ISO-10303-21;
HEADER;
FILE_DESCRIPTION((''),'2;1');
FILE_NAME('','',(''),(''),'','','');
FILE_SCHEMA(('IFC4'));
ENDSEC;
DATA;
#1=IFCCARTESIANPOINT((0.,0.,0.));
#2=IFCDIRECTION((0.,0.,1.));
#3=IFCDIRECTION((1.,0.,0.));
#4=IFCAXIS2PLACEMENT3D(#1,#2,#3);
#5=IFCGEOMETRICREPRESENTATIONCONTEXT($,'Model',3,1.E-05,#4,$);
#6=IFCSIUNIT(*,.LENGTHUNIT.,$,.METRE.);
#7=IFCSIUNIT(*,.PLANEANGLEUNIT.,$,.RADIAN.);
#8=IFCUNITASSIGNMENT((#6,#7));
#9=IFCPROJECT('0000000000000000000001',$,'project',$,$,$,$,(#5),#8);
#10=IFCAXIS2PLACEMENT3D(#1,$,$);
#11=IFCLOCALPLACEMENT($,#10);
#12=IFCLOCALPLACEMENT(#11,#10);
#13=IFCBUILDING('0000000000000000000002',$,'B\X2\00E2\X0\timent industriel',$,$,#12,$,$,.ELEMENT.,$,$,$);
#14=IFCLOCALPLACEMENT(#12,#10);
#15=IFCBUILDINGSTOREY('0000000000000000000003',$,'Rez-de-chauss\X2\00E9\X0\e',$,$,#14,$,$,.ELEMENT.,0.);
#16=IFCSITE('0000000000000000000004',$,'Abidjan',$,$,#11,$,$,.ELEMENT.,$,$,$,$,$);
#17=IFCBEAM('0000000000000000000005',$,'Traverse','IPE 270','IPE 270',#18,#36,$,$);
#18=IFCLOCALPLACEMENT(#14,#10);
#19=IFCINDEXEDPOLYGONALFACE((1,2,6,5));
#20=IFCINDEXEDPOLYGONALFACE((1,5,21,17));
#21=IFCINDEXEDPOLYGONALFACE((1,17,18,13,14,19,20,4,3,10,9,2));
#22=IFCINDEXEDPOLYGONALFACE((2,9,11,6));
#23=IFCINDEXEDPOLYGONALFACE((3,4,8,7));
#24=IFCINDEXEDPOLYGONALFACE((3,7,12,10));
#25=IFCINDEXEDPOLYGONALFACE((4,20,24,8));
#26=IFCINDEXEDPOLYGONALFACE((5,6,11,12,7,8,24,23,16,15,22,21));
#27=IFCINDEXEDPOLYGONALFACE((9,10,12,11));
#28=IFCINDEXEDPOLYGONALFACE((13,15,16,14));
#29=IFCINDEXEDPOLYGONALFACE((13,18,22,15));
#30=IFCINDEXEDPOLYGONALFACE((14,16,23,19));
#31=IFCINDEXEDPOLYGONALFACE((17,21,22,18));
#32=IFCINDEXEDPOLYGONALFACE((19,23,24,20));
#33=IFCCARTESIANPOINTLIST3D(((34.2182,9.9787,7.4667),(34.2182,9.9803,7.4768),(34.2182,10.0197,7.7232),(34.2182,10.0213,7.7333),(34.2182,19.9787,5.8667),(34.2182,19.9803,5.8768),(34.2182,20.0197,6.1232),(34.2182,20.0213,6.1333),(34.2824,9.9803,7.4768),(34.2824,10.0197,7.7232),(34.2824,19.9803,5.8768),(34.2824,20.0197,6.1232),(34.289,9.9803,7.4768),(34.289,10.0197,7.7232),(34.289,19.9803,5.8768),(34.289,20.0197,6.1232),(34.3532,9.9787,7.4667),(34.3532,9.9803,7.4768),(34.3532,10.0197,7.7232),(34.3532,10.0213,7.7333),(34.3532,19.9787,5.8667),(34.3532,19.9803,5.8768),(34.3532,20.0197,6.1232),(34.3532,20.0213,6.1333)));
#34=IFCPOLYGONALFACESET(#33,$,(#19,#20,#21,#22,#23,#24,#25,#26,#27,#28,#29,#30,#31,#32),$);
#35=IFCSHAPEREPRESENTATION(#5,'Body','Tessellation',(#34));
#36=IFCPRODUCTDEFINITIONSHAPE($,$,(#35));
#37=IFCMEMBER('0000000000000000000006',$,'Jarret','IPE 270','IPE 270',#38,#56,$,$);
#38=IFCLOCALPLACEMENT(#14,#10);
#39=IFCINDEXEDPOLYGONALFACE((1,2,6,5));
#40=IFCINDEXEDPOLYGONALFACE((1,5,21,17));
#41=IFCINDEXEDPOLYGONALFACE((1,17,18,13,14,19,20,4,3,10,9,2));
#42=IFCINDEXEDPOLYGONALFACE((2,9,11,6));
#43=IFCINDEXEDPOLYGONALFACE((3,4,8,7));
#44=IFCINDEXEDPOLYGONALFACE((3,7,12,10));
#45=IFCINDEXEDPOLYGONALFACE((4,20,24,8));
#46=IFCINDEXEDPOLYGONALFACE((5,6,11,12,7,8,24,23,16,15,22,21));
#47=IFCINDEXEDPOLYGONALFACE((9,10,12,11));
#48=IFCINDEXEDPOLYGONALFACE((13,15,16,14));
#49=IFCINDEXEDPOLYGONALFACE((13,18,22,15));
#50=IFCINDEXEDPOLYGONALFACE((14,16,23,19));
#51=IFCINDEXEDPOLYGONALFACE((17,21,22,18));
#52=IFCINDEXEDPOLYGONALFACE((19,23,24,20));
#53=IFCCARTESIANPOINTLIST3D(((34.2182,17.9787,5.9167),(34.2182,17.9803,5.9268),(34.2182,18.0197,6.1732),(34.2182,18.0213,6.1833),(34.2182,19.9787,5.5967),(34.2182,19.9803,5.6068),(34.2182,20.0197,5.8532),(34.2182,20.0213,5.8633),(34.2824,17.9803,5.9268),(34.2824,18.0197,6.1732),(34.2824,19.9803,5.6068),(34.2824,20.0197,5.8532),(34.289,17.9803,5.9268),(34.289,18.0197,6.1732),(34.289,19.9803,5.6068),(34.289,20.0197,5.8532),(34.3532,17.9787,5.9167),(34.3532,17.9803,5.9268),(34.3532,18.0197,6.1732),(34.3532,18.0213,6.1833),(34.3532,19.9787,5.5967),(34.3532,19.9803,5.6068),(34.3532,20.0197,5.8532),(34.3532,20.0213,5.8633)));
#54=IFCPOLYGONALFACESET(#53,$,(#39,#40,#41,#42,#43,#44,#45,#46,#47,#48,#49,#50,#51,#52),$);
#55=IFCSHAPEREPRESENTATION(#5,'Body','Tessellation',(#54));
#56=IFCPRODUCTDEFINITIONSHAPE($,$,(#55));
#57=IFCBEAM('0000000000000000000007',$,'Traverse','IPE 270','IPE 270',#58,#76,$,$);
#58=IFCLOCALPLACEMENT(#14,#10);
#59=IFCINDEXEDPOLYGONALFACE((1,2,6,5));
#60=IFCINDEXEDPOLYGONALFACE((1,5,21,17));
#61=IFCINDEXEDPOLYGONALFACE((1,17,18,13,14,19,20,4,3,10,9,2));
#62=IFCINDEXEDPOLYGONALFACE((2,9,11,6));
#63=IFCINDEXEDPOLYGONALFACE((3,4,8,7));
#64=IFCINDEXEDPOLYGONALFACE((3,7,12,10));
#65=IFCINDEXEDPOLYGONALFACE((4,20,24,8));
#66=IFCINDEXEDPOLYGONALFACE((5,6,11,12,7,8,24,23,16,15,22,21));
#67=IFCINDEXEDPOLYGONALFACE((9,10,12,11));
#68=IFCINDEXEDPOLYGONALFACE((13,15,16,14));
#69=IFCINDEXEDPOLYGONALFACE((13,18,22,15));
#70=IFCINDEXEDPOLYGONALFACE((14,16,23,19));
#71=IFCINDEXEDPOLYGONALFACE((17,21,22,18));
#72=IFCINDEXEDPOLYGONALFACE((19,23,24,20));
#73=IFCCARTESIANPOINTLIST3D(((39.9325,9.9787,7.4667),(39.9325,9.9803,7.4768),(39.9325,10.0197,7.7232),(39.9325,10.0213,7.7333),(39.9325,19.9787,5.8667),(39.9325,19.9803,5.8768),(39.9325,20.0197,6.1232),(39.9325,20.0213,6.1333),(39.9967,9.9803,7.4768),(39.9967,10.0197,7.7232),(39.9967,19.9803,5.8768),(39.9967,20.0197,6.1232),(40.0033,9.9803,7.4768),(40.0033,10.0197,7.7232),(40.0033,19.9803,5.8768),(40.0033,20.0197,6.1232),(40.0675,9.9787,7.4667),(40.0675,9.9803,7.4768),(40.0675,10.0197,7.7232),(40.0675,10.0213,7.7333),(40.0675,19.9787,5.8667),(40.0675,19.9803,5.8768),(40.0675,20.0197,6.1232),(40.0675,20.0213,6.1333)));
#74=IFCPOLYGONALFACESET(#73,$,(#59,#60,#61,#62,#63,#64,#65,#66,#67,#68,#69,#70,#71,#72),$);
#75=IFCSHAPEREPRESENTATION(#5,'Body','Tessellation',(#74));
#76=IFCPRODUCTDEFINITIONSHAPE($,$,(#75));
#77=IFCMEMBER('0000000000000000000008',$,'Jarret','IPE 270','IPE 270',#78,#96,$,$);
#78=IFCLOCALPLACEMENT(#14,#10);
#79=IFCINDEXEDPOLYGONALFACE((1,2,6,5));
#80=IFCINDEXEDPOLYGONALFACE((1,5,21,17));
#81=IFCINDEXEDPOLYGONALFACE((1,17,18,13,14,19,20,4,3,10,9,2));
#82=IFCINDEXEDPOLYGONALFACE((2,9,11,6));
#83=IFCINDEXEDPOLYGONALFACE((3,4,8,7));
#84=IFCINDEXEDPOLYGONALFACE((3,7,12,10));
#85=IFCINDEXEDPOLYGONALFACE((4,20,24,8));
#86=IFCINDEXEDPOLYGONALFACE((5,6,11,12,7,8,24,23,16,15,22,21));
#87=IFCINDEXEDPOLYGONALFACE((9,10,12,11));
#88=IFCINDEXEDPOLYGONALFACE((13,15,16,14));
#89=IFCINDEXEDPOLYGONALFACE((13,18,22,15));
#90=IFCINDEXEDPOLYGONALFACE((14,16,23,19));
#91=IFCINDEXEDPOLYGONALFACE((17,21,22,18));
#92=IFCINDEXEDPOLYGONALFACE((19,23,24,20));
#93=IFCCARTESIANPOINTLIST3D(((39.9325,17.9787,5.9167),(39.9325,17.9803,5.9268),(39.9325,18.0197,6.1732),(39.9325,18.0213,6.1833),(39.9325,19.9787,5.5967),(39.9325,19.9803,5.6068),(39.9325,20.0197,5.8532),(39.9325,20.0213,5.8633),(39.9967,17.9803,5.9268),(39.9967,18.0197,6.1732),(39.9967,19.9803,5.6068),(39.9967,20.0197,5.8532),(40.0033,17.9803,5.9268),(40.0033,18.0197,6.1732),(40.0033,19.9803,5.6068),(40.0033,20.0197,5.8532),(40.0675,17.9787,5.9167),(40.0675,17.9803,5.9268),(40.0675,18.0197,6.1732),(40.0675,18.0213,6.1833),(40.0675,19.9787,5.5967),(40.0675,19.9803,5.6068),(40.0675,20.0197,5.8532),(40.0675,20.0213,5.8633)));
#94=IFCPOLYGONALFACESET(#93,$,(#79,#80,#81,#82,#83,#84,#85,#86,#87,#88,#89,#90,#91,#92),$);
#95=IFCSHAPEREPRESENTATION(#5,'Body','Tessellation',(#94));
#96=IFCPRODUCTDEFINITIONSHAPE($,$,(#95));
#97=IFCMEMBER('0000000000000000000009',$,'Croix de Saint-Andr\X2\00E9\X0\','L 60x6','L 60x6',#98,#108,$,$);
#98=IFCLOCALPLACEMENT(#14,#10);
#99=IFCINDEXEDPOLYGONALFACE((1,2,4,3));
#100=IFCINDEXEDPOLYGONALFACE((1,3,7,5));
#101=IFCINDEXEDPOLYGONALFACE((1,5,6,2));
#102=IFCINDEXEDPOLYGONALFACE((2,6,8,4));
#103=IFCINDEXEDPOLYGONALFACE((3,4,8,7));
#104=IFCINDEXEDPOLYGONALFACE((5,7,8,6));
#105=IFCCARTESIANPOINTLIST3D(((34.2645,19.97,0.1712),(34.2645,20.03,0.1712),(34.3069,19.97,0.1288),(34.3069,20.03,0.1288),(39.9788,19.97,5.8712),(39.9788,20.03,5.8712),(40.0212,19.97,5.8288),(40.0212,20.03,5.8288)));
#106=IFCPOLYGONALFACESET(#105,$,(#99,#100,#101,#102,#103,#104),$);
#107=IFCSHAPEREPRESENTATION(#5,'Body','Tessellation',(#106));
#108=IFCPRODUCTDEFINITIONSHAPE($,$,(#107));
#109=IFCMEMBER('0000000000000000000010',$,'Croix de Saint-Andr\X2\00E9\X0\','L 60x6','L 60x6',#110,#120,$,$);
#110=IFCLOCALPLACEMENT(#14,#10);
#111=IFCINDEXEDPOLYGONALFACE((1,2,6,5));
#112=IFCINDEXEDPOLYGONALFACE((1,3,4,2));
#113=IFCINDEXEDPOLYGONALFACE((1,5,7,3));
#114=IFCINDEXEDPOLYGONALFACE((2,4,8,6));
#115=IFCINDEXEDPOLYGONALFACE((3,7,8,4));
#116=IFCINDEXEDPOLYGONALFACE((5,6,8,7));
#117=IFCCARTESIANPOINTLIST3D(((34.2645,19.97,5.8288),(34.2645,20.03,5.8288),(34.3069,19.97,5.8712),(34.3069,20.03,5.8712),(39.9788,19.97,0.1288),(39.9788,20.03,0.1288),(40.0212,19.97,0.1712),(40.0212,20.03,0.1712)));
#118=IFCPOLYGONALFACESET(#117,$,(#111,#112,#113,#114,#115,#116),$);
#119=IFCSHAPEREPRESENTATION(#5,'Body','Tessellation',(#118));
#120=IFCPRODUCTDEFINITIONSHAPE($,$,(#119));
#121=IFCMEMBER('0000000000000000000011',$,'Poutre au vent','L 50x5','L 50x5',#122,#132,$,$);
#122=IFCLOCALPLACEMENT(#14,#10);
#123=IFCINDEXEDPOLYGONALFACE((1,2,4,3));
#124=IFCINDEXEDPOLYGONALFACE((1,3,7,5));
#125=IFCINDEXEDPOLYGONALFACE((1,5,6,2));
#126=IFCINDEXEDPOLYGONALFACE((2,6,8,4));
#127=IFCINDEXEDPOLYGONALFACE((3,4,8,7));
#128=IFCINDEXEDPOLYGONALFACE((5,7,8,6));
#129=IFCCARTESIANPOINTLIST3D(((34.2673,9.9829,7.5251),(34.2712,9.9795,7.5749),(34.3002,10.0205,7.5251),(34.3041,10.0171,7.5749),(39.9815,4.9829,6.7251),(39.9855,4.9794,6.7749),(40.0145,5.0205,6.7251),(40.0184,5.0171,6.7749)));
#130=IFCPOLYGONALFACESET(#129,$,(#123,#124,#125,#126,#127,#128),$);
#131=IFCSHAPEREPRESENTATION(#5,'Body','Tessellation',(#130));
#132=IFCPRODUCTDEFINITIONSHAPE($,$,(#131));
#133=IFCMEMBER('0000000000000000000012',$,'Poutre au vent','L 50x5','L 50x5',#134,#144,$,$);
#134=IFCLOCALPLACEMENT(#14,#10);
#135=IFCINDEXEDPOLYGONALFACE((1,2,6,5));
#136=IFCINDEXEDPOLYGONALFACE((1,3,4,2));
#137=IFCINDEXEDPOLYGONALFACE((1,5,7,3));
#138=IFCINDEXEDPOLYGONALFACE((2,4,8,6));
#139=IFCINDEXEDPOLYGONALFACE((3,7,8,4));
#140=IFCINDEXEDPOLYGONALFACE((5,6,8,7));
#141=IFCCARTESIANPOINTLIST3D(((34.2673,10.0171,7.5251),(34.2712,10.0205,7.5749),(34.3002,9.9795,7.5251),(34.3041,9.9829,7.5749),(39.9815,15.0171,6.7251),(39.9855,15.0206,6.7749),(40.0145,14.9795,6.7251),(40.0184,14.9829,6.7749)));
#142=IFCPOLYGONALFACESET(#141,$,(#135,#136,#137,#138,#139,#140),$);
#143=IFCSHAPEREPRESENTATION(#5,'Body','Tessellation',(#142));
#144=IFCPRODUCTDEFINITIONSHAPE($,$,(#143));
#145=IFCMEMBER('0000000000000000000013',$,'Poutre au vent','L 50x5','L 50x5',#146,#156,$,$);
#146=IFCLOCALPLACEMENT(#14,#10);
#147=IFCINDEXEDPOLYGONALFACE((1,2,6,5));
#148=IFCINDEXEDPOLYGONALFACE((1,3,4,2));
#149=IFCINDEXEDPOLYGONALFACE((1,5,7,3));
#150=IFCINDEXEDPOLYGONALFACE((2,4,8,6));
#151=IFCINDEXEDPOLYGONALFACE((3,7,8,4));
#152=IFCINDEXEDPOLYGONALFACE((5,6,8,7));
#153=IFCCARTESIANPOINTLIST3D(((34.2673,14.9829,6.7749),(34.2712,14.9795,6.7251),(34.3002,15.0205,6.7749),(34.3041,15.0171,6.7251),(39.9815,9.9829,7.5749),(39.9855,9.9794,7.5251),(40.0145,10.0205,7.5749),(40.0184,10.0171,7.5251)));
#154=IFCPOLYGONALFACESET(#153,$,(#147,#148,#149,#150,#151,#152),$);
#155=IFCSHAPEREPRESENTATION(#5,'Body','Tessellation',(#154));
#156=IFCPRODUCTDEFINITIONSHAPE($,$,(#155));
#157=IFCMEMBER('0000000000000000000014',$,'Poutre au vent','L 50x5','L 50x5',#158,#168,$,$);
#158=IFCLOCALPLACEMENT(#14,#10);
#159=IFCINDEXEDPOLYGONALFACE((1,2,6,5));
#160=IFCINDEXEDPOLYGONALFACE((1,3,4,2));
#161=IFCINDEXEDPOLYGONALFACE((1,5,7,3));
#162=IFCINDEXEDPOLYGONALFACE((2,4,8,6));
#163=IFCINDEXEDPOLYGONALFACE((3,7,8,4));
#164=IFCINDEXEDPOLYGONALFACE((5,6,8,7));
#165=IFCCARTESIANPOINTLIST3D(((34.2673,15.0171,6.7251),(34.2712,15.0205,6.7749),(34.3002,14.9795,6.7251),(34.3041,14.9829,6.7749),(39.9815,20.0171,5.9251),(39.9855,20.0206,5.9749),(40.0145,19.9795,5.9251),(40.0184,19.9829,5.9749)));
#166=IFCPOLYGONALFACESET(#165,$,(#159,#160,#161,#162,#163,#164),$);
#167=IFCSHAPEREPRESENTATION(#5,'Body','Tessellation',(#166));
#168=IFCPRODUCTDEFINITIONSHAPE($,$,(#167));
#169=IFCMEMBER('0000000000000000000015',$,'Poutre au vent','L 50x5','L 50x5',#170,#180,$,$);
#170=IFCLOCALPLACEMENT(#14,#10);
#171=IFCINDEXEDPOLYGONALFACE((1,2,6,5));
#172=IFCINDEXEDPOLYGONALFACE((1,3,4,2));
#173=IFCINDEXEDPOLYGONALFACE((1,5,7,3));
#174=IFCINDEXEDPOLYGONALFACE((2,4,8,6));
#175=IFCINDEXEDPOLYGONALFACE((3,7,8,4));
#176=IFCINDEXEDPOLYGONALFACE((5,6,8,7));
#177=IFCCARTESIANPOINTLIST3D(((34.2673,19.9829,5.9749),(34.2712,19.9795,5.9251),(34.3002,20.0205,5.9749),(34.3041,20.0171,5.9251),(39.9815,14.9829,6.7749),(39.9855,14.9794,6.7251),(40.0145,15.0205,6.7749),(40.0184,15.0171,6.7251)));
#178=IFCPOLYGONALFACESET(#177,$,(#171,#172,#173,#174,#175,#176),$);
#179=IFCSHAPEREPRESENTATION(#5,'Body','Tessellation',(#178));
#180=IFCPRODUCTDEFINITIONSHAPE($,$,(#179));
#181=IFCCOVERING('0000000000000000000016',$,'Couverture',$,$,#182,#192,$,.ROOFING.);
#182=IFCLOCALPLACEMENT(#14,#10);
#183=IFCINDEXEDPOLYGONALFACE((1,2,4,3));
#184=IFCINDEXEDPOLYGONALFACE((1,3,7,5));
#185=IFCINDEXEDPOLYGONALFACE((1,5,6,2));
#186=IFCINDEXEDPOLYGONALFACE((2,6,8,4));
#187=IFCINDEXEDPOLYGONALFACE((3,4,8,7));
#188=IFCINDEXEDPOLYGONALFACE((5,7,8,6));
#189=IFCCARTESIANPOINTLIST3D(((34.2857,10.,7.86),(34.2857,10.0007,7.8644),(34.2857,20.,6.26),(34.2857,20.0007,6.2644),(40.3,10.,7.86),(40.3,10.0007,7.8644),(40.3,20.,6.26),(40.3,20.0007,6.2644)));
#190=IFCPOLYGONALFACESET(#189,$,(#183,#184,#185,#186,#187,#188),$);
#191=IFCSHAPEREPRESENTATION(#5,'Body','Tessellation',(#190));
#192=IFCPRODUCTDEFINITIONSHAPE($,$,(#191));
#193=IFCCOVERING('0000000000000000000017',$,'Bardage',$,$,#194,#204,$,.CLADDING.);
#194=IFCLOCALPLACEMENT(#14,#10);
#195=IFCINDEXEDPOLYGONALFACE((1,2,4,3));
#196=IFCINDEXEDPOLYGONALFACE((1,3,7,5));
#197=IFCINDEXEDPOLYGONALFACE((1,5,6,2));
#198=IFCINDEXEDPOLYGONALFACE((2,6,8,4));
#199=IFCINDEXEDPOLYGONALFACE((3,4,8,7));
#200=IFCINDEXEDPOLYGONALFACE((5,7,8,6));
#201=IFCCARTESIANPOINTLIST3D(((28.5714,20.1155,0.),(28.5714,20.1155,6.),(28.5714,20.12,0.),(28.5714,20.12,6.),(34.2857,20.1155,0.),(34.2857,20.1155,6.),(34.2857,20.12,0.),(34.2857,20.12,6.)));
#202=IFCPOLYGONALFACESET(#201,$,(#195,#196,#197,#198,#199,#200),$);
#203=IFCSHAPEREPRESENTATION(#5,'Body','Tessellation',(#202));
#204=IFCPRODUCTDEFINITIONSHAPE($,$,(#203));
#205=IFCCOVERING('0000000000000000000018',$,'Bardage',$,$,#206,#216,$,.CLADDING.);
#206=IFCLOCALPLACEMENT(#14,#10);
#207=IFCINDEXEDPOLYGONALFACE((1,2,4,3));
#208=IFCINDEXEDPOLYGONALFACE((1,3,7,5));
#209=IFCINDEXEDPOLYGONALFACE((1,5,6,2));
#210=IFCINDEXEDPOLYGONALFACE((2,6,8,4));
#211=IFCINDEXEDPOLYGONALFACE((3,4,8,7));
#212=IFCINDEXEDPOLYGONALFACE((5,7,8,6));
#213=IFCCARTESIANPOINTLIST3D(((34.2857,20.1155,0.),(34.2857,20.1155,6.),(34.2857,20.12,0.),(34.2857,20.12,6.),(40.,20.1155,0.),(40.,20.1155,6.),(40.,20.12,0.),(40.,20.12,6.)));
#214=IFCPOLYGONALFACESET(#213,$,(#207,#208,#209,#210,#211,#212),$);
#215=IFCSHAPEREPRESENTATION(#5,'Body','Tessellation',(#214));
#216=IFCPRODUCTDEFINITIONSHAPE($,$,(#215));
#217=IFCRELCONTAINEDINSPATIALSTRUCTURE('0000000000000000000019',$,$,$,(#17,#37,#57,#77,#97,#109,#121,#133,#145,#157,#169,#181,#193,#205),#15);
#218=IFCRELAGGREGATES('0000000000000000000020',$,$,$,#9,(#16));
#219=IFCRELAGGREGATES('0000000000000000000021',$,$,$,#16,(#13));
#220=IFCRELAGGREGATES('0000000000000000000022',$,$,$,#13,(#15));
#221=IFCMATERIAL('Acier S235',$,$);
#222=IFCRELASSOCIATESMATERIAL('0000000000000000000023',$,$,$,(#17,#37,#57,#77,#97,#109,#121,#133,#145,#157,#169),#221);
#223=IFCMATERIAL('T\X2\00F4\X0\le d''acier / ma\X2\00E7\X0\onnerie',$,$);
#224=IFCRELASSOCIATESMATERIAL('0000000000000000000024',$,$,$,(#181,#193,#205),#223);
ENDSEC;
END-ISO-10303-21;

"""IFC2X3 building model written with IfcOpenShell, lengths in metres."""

from ifc_helpers import new_model, si_unit, frame, origin, origin_with_axes, origin_2d, place, context, project, spatial, polyline, rectangle, i_section, outline, extrude, material, element, save


model = new_model("IFC2X3")

# Units and contexts
model_context = context("Model", 3, precision=1e-05, world=origin_with_axes())
ifc_project = project(units=[si_unit("LENGTHUNIT", "METRE"), si_unit("PLANEANGLEUNIT", "RADIAN")], contexts=[model_context])

# Site, building, storey
site_placement = place(None, origin())
site = spatial("IfcSite", under=ifc_project, at=site_placement, Name="Abidjan", CompositionType="ELEMENT")
building_placement = place(site_placement, origin())
building = spatial("IfcBuilding", under=site, at=building_placement, Name="Bâtiment industriel", CompositionType="ELEMENT")
storey_placement = place(building_placement, origin())
storey = spatial("IfcBuildingStorey", under=building, at=storey_placement, Name="Rez-de-chaussée", CompositionType="ELEMENT", Elevation=0.0)

# Shared definitions
ifc_material_1 = material(Name="Acier S235")

# Beam
beam_1_placement = place(storey_placement, frame((34.2857, 10.0, 7.6), z_axis=(0.0, 0.98744, -0.15799), x_axis=(1.0, 0.0, 0.0)))
element("IfcBeam", 1, at=beam_1_placement, inside=storey, material=ifc_material_1, Name="Traverse", Description="IPE 270", ObjectType="IPE 270", context=model_context, shape_type="SweptSolid", body=[
    extrude(i_section(OverallWidth=0.135, OverallDepth=0.27, WebThickness=0.0066, FlangeThickness=0.0102, at=origin_2d()), origin(), (0.0, 0.0, 1.0), 10.1272),
])

# Member
member_1_placement = place(storey_placement, frame((34.2857, 20.0, 5.73), z_axis=(0.0, -0.98744, 0.15799), x_axis=(1.0, 0.0, 0.0)))
element("IfcMember", 2, at=member_1_placement, inside=storey, material=ifc_material_1, Name="Jarret", Description="IPE 270", ObjectType="IPE 270", context=model_context, shape_type="SweptSolid", body=[
    extrude(i_section(OverallWidth=0.135, OverallDepth=0.27, WebThickness=0.0066, FlangeThickness=0.0102, at=origin_2d()), origin(), (0.0, 0.0, 1.0), 2.0254),
])

# Beam
beam_2_placement = place(storey_placement, frame((40.0, 10.0, 7.6), z_axis=(0.0, 0.98744, -0.15799), x_axis=(1.0, 0.0, 0.0)))
element("IfcBeam", 3, at=beam_2_placement, inside=storey, material=ifc_material_1, Name="Traverse", Description="IPE 270", ObjectType="IPE 270", context=model_context, shape_type="SweptSolid", body=[
    extrude(i_section(OverallWidth=0.135, OverallDepth=0.27, WebThickness=0.0066, FlangeThickness=0.0102, at=origin_2d()), origin(), (0.0, 0.0, 1.0), 10.1272),
])

# Members
member_2_placement = place(storey_placement, frame((40.0, 20.0, 5.73), z_axis=(0.0, -0.98744, 0.15799), x_axis=(1.0, 0.0, 0.0)))
element("IfcMember", 4, at=member_2_placement, inside=storey, material=ifc_material_1, Name="Jarret", Description="IPE 270", ObjectType="IPE 270", context=model_context, shape_type="SweptSolid", body=[
    extrude(i_section(OverallWidth=0.135, OverallDepth=0.27, WebThickness=0.0066, FlangeThickness=0.0102, at=origin_2d()), origin(), (0.0, 0.0, 1.0), 2.0254),
])
for number, where, z_axis, x_axis, name in (
    (5, (34.2857, 20.0, 0.15), (0.70799, 0.0, 0.70622), (0.0, 1.0, 0.0), "Croix de Saint-André"),
    (6, (40.0, 20.0, 0.15), (-0.70799, 0.0, 0.70622), (0.0, 1.0, 0.0), "Croix de Saint-André"),
):
    element("IfcMember", number, at=place(storey_placement, frame(where, z_axis=z_axis, x_axis=x_axis)), inside=storey, material=ifc_material_1, Name=name, Description="L 60x6", ObjectType="L 60x6", context=model_context, shape_type="SweptSolid", body=[
        extrude(rectangle(XDim=0.06, YDim=0.06, at=origin_2d()), origin(), (0.0, 0.0, 1.0), 8.0711),
    ])
for number, where, z_axis, x_axis, name in (
    (7, (34.2857, 10.0, 7.55), (0.74843, -0.65488, -0.10478), (0.07886, -0.069, 0.9945), "Poutre au vent"),
    (8, (34.2857, 10.0, 7.55), (0.74843, 0.65488, -0.10478), (0.07886, 0.069, 0.9945), "Poutre au vent"),
    (9, (34.2857, 15.0, 6.75), (0.74843, -0.65488, 0.10478), (-0.07886, 0.069, 0.9945), "Poutre au vent"),
    (10, (34.2857, 15.0, 6.75), (0.74843, 0.65488, -0.10478), (0.07886, 0.069, 0.9945), "Poutre au vent"),
    (11, (34.2857, 20.0, 5.95), (0.74843, -0.65488, 0.10478), (-0.07886, 0.069, 0.9945), "Poutre au vent"),
):
    element("IfcMember", number, at=place(storey_placement, frame(where, z_axis=z_axis, x_axis=x_axis)), inside=storey, material=ifc_material_1, Name=name, Description="L 50x5", ObjectType="L 50x5", context=model_context, shape_type="SweptSolid", body=[
        extrude(rectangle(XDim=0.05, YDim=0.05, at=origin_2d()), origin(), (0.0, 0.0, 1.0), 7.635),
    ])

# Coverings
ifc_material_2 = material(Name="Tôle d'acier / maçonnerie")
covering_placement = place(storey_placement, frame((34.2857, 10.0, 7.86), z_axis=(0.0, 0.15799, 0.98744), x_axis=(1.0, 0.0, 0.0)))
element("IfcCovering", 12, at=covering_placement, inside=storey, material=ifc_material_2, Name="Couverture", PredefinedType="ROOFING", context=model_context, shape_type="SweptSolid", body=[
    extrude(outline(polyline([(0.0, 0.0), (6.0143, 0.0), (6.0143, 10.1272), (0.0, 10.1272), (0.0, 0.0)])), origin(), (0.0, 0.0, 1.0), 0.0045),
])
for number, where, z_axis, x_axis, name in (
    (13, (28.5714, 20.12, 0.0), (0.0, -1.0, 0.0), (1.0, 0.0, 0.0), "Bardage"),
    (14, (34.2857, 20.12, 0.0), (0.0, -1.0, 0.0), (1.0, 0.0, 0.0), "Bardage"),
):
    element("IfcCovering", number, at=place(storey_placement, frame(where, z_axis=z_axis, x_axis=x_axis)), inside=storey, material=ifc_material_2, Name=name, PredefinedType="CLADDING", context=model_context, shape_type="SweptSolid", body=[
        extrude(outline(polyline([(0.0, 0.0), (5.7143, 0.0), (5.7143, 6.0), (0.0, 6.0), (0.0, 0.0)])), origin(), (0.0, 0.0, 1.0), 0.0045),
    ])

save(model, "model.ifc")
